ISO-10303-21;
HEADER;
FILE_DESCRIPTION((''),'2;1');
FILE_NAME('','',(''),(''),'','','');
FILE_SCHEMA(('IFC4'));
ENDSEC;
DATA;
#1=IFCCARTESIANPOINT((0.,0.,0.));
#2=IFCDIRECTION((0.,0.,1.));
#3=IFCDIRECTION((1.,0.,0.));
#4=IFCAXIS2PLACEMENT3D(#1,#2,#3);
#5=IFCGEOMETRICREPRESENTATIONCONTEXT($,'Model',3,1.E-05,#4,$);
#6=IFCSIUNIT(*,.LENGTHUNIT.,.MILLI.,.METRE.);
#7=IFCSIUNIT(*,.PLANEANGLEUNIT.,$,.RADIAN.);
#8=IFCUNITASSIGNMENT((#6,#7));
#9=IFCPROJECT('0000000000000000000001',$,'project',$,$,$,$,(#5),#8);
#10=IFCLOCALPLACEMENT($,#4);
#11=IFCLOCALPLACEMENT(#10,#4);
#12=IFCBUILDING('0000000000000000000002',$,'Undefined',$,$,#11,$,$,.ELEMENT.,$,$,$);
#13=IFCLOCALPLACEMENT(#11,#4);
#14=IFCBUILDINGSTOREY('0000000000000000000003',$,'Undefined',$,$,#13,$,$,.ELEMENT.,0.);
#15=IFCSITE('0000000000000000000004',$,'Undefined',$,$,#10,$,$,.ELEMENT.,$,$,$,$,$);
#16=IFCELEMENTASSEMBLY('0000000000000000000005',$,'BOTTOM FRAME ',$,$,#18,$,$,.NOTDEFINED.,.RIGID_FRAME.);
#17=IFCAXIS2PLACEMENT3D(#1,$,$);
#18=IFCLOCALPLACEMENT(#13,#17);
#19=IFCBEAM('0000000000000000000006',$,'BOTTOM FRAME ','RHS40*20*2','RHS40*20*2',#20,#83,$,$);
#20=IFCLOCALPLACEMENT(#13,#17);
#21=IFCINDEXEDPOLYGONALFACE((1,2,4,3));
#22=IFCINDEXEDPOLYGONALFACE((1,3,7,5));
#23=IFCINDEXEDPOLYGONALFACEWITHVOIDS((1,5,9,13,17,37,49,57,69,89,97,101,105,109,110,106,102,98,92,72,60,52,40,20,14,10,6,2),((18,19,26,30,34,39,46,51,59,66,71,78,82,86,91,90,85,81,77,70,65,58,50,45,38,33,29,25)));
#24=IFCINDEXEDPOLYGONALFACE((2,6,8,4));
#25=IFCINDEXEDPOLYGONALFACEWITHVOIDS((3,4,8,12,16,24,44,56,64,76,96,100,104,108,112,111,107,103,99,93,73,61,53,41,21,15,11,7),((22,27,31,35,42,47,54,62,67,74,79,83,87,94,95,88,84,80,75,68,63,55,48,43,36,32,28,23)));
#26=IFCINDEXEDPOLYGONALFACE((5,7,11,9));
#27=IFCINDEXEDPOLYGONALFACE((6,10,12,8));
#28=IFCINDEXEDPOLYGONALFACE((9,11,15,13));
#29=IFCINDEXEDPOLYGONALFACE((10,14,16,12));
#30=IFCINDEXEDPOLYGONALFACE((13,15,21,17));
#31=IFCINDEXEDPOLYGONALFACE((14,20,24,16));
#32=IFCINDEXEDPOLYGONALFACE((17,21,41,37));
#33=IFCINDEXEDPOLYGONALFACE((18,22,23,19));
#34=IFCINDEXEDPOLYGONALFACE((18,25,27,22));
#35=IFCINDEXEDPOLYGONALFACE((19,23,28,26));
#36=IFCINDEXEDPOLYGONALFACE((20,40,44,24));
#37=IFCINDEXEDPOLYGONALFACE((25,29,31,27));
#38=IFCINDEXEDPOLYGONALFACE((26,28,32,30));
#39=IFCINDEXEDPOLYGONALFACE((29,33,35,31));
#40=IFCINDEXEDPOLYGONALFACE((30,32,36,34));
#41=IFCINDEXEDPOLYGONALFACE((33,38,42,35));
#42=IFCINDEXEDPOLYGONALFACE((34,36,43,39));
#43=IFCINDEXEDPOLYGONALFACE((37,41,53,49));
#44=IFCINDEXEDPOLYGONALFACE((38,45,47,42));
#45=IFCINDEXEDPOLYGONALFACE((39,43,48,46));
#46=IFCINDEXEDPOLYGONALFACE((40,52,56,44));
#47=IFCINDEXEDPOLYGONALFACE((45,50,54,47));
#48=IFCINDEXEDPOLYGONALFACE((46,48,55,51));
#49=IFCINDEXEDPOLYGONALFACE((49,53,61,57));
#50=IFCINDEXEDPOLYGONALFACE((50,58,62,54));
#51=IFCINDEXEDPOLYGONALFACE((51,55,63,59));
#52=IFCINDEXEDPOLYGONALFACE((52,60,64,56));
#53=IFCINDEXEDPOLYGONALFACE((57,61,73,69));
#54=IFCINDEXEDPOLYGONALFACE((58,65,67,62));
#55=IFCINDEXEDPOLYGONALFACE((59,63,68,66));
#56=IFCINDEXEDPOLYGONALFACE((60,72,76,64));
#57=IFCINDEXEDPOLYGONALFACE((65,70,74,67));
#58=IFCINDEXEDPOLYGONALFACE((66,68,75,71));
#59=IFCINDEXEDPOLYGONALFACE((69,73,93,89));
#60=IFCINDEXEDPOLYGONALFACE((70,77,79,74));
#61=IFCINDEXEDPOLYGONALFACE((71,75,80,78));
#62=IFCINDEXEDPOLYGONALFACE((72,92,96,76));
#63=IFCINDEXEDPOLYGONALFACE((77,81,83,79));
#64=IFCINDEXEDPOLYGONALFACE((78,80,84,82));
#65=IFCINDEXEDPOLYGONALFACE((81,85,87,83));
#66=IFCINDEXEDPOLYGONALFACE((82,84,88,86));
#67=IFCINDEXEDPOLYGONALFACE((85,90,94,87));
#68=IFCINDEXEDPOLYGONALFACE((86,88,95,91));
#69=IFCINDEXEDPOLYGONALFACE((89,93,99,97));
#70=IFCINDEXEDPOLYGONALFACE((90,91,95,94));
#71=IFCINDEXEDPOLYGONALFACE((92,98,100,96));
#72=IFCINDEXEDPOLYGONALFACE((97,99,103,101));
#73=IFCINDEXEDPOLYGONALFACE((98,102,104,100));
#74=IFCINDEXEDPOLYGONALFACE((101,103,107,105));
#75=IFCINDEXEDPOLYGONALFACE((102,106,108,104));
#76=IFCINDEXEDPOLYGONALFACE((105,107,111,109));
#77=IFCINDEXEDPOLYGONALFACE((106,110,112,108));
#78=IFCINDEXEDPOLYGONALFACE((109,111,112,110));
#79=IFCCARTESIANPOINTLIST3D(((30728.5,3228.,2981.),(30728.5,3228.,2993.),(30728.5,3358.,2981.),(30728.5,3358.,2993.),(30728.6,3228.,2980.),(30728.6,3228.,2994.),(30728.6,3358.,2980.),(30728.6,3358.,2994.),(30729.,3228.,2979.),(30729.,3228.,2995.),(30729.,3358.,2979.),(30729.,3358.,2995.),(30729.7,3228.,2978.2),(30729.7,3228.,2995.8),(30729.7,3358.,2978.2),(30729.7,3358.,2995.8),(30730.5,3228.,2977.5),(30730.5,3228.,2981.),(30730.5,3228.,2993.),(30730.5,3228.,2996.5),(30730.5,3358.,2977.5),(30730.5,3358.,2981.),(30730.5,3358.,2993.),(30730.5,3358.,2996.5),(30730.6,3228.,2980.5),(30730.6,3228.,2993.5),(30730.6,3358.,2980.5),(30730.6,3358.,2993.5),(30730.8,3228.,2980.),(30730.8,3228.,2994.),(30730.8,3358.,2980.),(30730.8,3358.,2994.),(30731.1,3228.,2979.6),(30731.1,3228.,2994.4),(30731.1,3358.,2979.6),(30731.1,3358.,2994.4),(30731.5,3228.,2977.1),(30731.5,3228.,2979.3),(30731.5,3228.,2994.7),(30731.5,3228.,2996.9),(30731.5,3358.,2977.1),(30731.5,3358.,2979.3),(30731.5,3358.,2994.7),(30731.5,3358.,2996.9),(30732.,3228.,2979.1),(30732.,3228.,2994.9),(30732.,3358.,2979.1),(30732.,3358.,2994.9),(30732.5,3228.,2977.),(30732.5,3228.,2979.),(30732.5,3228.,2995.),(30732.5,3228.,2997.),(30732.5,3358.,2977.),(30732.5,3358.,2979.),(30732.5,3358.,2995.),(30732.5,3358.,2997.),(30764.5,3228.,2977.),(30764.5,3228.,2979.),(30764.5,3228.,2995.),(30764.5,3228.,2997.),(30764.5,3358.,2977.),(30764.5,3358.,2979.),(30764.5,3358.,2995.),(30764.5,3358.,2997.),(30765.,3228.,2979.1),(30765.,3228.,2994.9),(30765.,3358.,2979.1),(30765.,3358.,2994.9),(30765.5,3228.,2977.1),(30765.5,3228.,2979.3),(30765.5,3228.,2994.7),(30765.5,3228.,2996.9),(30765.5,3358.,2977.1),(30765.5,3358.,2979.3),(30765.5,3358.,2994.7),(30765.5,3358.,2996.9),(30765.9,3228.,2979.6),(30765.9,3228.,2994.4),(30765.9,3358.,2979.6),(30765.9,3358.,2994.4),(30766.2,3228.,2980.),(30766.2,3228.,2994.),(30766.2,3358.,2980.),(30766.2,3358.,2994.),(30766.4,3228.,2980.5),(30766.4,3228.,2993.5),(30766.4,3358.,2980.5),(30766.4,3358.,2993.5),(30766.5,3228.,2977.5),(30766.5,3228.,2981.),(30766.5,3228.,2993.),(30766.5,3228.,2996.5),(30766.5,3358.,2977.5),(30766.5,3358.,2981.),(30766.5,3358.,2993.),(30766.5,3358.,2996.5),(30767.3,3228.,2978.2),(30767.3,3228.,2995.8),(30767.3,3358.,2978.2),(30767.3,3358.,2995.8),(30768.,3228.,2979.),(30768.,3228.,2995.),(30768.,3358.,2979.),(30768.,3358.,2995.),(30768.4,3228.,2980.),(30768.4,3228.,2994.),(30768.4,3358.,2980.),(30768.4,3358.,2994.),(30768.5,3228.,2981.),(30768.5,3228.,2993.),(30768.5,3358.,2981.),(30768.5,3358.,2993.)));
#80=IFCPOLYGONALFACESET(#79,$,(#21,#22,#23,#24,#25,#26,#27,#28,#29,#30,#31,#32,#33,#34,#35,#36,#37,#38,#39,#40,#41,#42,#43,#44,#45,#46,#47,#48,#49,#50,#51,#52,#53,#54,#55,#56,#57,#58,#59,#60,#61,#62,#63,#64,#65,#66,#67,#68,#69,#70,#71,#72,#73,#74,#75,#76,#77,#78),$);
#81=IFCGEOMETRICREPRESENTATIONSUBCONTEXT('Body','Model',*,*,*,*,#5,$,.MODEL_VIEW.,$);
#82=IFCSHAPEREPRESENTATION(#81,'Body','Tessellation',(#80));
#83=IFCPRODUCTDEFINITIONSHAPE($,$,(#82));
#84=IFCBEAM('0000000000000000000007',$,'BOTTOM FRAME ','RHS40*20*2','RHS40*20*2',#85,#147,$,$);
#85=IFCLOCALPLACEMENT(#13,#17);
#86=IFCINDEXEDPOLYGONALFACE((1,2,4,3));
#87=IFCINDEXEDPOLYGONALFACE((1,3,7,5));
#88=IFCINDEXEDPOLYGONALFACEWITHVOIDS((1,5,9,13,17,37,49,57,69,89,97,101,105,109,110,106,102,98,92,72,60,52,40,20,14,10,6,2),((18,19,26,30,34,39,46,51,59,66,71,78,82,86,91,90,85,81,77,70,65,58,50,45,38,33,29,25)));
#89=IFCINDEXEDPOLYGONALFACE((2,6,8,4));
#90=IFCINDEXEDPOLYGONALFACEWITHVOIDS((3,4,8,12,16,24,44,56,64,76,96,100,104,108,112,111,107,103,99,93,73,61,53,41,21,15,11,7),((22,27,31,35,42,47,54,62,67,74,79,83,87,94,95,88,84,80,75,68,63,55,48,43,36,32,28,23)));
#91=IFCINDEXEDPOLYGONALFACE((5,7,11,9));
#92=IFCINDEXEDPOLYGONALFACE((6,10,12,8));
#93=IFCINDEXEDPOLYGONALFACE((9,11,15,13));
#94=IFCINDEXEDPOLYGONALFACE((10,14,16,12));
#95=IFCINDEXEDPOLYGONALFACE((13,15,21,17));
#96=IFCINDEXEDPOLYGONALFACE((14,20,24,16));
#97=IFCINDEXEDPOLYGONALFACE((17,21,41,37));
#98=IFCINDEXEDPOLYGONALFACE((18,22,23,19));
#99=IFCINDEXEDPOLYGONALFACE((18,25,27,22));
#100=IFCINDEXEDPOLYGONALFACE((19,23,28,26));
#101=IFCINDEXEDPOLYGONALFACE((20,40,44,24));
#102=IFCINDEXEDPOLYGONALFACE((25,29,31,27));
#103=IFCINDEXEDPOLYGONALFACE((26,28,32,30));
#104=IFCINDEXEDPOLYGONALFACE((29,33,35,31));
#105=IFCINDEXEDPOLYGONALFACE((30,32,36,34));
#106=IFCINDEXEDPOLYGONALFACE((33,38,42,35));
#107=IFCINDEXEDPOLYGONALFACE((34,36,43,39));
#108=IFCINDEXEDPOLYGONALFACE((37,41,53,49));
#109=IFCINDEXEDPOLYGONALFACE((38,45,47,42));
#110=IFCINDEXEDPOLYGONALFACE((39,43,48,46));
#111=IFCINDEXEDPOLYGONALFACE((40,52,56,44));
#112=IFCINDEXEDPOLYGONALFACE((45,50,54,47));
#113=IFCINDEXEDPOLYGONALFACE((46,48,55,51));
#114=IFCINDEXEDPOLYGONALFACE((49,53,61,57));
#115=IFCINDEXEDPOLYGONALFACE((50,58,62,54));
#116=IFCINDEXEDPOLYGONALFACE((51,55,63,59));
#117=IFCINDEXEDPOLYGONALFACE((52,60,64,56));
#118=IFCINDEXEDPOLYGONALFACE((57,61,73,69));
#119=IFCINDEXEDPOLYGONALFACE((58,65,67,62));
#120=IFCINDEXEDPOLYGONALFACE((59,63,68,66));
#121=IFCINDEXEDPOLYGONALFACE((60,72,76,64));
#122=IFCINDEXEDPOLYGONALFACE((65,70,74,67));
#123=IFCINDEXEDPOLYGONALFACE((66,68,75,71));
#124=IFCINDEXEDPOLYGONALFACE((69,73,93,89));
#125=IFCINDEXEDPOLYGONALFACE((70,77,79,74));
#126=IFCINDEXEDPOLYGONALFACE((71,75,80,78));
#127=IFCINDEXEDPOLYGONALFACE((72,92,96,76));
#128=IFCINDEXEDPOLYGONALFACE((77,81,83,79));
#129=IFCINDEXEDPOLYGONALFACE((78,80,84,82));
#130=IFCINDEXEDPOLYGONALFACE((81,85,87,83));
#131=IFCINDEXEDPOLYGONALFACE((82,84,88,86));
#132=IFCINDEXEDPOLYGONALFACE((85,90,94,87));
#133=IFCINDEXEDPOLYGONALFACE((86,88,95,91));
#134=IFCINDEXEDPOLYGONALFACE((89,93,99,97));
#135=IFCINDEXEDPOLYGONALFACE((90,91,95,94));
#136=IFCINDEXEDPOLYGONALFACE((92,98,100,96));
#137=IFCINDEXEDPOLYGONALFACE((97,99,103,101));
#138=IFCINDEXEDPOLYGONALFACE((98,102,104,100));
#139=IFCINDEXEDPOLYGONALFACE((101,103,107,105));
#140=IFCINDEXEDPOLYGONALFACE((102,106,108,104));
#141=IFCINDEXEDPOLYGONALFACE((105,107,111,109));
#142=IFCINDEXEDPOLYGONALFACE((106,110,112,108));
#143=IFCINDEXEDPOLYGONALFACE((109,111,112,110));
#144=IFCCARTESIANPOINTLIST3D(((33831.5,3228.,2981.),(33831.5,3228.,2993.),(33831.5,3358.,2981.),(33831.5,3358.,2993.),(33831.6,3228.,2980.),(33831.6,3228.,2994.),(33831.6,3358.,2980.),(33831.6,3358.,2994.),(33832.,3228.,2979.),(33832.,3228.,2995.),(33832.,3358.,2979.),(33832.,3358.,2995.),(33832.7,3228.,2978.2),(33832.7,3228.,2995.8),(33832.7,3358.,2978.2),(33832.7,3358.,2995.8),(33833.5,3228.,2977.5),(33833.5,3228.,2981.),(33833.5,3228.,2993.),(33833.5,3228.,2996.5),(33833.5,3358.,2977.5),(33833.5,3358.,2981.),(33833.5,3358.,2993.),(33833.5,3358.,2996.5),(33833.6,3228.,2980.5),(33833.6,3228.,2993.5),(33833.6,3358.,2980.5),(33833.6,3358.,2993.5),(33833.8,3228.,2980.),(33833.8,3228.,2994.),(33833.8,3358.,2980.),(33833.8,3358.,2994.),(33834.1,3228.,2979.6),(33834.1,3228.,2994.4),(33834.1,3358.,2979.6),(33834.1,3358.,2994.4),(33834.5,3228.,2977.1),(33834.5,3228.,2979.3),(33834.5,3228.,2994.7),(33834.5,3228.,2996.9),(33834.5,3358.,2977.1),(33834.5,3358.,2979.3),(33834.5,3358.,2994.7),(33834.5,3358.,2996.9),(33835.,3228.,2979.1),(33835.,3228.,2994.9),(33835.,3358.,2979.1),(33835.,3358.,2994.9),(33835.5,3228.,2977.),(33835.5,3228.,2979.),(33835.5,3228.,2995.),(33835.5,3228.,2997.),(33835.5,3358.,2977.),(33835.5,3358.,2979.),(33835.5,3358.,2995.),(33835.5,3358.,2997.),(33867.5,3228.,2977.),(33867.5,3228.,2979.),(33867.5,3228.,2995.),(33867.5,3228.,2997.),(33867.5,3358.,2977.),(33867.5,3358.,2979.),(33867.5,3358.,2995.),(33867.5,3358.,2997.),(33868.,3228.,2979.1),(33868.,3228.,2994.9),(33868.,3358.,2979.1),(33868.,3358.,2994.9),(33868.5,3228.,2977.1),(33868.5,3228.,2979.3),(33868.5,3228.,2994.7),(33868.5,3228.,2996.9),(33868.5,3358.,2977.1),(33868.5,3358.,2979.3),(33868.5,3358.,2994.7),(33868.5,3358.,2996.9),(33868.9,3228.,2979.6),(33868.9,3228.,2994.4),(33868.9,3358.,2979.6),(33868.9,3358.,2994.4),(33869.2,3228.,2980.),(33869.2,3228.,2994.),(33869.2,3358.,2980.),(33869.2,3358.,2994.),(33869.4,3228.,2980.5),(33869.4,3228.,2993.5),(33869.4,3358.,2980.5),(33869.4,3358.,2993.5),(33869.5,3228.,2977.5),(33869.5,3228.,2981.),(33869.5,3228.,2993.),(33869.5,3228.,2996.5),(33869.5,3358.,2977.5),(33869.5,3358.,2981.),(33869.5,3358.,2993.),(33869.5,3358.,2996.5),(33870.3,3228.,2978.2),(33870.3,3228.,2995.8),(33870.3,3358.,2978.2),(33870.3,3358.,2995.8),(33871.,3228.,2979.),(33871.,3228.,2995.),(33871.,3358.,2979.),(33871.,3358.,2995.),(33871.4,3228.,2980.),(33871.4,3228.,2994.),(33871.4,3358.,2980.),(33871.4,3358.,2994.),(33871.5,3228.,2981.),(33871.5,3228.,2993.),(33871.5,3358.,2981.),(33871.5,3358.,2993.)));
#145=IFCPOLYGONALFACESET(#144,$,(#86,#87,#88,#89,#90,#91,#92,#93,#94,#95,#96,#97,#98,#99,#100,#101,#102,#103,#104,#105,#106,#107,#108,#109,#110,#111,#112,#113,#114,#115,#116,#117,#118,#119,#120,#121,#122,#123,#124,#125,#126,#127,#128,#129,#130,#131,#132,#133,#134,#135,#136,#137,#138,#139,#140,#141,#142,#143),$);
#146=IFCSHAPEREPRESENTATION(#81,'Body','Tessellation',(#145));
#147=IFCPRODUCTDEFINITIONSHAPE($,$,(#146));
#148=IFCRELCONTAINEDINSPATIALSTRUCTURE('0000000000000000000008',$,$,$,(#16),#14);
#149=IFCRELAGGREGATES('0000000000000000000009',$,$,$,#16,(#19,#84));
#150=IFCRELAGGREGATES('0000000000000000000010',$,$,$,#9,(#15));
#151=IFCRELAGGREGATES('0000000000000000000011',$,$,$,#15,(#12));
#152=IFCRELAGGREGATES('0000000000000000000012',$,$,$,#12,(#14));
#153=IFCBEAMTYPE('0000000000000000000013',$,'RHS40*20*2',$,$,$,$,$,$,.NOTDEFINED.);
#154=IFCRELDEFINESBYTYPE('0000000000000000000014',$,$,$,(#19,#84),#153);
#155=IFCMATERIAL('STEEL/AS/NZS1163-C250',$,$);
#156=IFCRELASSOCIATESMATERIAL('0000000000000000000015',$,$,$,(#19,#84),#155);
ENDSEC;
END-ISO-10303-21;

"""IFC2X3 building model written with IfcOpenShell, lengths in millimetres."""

from ifc_helpers import new_model, si_unit, frame, origin_with_axes, origin_2d_with_axis, place, context, subcontext, project, spatial, hollow_rectangle, extrude, material, type_object, element, aggregate, save


model = new_model("IFC2X3")

# Units and contexts
model_context = context("Model", 3, precision=1e-05, world=origin_with_axes())
body_context = subcontext(model_context, "Body", "Model", "MODEL_VIEW")
ifc_project = project(units=[si_unit("LENGTHUNIT", "METRE", prefix="MILLI"), si_unit("PLANEANGLEUNIT", "RADIAN")], contexts=[model_context])

# Site, building, storey
site_placement = place(None, origin_with_axes())
site = spatial("IfcSite", under=ifc_project, at=site_placement, Name="Undefined", CompositionType="ELEMENT")
building_placement = place(site_placement, origin_with_axes())
building = spatial("IfcBuilding", under=site, at=building_placement, Name="Undefined", CompositionType="ELEMENT")
storey_placement = place(building_placement, origin_with_axes())
storey = spatial("IfcBuildingStorey", under=building, at=storey_placement, Name="Undefined", CompositionType="ELEMENT", Elevation=0.0)

# Element assembly, beams
assembly_1_placement = place(storey_placement, origin_with_axes())
assembly_1 = element("IfcElementAssembly", 1, at=assembly_1_placement, inside=storey, Name="BOTTOM FRAME ", AssemblyPlace="NOTDEFINED", PredefinedType="RIGID_FRAME")
ifc_material_1 = material(Name="STEEL/AS/NZS1163-C250")
beam_type_1 = type_object("IfcBeamType", Name="RHS40*20*2", PredefinedType="NOTDEFINED")
beam_1_placement = place(assembly_1_placement, frame((30748.5, 3358.0, 2987.0), z_axis=(1.0, 0.0, 0.0), x_axis=(0.0, -1.0, 0.0)))
beam_1 = element("IfcBeam", 2, at=beam_1_placement, type_object=beam_type_1, material=ifc_material_1, Name="BOTTOM FRAME ", Description="RHS40*20*2", ObjectType="RHS40*20*2", context=body_context, shape_type="SweptSolid", body=[
    extrude(hollow_rectangle(XDim=20.0, YDim=40.0, WallThickness=2.0, InnerFilletRadius=2.0, OuterFilletRadius=4.0, at=origin_2d_with_axis()), frame((130.0, 0.0, 0.0), z_axis=(-1.0, 0.0, 0.0), x_axis=(0.0, -1.0, 0.0)), (0.0, 0.0, 1.0), 130.0),
])
beam_2_placement = place(assembly_1_placement, frame((33851.5, 3358.0, 2987.0), z_axis=(-1.0, 0.0, 0.0), x_axis=(0.0, -1.0, 0.0)))
beam_2 = element("IfcBeam", 3, at=beam_2_placement, type_object=beam_type_1, material=ifc_material_1, Name="BOTTOM FRAME ", Description="RHS40*20*2", ObjectType="RHS40*20*2", context=body_context, shape_type="SweptSolid", body=[
    extrude(hollow_rectangle(XDim=20.0, YDim=40.0, WallThickness=2.0, InnerFilletRadius=2.0, OuterFilletRadius=4.0, at=origin_2d_with_axis()), frame((130.0, 0.0, 0.0), z_axis=(-1.0, 0.0, 0.0), x_axis=(0.0, -1.0, 0.0)), (0.0, 0.0, 1.0), 130.0),
])
aggregate(assembly_1, [beam_1, beam_2])

save(model, "model.ifc")
